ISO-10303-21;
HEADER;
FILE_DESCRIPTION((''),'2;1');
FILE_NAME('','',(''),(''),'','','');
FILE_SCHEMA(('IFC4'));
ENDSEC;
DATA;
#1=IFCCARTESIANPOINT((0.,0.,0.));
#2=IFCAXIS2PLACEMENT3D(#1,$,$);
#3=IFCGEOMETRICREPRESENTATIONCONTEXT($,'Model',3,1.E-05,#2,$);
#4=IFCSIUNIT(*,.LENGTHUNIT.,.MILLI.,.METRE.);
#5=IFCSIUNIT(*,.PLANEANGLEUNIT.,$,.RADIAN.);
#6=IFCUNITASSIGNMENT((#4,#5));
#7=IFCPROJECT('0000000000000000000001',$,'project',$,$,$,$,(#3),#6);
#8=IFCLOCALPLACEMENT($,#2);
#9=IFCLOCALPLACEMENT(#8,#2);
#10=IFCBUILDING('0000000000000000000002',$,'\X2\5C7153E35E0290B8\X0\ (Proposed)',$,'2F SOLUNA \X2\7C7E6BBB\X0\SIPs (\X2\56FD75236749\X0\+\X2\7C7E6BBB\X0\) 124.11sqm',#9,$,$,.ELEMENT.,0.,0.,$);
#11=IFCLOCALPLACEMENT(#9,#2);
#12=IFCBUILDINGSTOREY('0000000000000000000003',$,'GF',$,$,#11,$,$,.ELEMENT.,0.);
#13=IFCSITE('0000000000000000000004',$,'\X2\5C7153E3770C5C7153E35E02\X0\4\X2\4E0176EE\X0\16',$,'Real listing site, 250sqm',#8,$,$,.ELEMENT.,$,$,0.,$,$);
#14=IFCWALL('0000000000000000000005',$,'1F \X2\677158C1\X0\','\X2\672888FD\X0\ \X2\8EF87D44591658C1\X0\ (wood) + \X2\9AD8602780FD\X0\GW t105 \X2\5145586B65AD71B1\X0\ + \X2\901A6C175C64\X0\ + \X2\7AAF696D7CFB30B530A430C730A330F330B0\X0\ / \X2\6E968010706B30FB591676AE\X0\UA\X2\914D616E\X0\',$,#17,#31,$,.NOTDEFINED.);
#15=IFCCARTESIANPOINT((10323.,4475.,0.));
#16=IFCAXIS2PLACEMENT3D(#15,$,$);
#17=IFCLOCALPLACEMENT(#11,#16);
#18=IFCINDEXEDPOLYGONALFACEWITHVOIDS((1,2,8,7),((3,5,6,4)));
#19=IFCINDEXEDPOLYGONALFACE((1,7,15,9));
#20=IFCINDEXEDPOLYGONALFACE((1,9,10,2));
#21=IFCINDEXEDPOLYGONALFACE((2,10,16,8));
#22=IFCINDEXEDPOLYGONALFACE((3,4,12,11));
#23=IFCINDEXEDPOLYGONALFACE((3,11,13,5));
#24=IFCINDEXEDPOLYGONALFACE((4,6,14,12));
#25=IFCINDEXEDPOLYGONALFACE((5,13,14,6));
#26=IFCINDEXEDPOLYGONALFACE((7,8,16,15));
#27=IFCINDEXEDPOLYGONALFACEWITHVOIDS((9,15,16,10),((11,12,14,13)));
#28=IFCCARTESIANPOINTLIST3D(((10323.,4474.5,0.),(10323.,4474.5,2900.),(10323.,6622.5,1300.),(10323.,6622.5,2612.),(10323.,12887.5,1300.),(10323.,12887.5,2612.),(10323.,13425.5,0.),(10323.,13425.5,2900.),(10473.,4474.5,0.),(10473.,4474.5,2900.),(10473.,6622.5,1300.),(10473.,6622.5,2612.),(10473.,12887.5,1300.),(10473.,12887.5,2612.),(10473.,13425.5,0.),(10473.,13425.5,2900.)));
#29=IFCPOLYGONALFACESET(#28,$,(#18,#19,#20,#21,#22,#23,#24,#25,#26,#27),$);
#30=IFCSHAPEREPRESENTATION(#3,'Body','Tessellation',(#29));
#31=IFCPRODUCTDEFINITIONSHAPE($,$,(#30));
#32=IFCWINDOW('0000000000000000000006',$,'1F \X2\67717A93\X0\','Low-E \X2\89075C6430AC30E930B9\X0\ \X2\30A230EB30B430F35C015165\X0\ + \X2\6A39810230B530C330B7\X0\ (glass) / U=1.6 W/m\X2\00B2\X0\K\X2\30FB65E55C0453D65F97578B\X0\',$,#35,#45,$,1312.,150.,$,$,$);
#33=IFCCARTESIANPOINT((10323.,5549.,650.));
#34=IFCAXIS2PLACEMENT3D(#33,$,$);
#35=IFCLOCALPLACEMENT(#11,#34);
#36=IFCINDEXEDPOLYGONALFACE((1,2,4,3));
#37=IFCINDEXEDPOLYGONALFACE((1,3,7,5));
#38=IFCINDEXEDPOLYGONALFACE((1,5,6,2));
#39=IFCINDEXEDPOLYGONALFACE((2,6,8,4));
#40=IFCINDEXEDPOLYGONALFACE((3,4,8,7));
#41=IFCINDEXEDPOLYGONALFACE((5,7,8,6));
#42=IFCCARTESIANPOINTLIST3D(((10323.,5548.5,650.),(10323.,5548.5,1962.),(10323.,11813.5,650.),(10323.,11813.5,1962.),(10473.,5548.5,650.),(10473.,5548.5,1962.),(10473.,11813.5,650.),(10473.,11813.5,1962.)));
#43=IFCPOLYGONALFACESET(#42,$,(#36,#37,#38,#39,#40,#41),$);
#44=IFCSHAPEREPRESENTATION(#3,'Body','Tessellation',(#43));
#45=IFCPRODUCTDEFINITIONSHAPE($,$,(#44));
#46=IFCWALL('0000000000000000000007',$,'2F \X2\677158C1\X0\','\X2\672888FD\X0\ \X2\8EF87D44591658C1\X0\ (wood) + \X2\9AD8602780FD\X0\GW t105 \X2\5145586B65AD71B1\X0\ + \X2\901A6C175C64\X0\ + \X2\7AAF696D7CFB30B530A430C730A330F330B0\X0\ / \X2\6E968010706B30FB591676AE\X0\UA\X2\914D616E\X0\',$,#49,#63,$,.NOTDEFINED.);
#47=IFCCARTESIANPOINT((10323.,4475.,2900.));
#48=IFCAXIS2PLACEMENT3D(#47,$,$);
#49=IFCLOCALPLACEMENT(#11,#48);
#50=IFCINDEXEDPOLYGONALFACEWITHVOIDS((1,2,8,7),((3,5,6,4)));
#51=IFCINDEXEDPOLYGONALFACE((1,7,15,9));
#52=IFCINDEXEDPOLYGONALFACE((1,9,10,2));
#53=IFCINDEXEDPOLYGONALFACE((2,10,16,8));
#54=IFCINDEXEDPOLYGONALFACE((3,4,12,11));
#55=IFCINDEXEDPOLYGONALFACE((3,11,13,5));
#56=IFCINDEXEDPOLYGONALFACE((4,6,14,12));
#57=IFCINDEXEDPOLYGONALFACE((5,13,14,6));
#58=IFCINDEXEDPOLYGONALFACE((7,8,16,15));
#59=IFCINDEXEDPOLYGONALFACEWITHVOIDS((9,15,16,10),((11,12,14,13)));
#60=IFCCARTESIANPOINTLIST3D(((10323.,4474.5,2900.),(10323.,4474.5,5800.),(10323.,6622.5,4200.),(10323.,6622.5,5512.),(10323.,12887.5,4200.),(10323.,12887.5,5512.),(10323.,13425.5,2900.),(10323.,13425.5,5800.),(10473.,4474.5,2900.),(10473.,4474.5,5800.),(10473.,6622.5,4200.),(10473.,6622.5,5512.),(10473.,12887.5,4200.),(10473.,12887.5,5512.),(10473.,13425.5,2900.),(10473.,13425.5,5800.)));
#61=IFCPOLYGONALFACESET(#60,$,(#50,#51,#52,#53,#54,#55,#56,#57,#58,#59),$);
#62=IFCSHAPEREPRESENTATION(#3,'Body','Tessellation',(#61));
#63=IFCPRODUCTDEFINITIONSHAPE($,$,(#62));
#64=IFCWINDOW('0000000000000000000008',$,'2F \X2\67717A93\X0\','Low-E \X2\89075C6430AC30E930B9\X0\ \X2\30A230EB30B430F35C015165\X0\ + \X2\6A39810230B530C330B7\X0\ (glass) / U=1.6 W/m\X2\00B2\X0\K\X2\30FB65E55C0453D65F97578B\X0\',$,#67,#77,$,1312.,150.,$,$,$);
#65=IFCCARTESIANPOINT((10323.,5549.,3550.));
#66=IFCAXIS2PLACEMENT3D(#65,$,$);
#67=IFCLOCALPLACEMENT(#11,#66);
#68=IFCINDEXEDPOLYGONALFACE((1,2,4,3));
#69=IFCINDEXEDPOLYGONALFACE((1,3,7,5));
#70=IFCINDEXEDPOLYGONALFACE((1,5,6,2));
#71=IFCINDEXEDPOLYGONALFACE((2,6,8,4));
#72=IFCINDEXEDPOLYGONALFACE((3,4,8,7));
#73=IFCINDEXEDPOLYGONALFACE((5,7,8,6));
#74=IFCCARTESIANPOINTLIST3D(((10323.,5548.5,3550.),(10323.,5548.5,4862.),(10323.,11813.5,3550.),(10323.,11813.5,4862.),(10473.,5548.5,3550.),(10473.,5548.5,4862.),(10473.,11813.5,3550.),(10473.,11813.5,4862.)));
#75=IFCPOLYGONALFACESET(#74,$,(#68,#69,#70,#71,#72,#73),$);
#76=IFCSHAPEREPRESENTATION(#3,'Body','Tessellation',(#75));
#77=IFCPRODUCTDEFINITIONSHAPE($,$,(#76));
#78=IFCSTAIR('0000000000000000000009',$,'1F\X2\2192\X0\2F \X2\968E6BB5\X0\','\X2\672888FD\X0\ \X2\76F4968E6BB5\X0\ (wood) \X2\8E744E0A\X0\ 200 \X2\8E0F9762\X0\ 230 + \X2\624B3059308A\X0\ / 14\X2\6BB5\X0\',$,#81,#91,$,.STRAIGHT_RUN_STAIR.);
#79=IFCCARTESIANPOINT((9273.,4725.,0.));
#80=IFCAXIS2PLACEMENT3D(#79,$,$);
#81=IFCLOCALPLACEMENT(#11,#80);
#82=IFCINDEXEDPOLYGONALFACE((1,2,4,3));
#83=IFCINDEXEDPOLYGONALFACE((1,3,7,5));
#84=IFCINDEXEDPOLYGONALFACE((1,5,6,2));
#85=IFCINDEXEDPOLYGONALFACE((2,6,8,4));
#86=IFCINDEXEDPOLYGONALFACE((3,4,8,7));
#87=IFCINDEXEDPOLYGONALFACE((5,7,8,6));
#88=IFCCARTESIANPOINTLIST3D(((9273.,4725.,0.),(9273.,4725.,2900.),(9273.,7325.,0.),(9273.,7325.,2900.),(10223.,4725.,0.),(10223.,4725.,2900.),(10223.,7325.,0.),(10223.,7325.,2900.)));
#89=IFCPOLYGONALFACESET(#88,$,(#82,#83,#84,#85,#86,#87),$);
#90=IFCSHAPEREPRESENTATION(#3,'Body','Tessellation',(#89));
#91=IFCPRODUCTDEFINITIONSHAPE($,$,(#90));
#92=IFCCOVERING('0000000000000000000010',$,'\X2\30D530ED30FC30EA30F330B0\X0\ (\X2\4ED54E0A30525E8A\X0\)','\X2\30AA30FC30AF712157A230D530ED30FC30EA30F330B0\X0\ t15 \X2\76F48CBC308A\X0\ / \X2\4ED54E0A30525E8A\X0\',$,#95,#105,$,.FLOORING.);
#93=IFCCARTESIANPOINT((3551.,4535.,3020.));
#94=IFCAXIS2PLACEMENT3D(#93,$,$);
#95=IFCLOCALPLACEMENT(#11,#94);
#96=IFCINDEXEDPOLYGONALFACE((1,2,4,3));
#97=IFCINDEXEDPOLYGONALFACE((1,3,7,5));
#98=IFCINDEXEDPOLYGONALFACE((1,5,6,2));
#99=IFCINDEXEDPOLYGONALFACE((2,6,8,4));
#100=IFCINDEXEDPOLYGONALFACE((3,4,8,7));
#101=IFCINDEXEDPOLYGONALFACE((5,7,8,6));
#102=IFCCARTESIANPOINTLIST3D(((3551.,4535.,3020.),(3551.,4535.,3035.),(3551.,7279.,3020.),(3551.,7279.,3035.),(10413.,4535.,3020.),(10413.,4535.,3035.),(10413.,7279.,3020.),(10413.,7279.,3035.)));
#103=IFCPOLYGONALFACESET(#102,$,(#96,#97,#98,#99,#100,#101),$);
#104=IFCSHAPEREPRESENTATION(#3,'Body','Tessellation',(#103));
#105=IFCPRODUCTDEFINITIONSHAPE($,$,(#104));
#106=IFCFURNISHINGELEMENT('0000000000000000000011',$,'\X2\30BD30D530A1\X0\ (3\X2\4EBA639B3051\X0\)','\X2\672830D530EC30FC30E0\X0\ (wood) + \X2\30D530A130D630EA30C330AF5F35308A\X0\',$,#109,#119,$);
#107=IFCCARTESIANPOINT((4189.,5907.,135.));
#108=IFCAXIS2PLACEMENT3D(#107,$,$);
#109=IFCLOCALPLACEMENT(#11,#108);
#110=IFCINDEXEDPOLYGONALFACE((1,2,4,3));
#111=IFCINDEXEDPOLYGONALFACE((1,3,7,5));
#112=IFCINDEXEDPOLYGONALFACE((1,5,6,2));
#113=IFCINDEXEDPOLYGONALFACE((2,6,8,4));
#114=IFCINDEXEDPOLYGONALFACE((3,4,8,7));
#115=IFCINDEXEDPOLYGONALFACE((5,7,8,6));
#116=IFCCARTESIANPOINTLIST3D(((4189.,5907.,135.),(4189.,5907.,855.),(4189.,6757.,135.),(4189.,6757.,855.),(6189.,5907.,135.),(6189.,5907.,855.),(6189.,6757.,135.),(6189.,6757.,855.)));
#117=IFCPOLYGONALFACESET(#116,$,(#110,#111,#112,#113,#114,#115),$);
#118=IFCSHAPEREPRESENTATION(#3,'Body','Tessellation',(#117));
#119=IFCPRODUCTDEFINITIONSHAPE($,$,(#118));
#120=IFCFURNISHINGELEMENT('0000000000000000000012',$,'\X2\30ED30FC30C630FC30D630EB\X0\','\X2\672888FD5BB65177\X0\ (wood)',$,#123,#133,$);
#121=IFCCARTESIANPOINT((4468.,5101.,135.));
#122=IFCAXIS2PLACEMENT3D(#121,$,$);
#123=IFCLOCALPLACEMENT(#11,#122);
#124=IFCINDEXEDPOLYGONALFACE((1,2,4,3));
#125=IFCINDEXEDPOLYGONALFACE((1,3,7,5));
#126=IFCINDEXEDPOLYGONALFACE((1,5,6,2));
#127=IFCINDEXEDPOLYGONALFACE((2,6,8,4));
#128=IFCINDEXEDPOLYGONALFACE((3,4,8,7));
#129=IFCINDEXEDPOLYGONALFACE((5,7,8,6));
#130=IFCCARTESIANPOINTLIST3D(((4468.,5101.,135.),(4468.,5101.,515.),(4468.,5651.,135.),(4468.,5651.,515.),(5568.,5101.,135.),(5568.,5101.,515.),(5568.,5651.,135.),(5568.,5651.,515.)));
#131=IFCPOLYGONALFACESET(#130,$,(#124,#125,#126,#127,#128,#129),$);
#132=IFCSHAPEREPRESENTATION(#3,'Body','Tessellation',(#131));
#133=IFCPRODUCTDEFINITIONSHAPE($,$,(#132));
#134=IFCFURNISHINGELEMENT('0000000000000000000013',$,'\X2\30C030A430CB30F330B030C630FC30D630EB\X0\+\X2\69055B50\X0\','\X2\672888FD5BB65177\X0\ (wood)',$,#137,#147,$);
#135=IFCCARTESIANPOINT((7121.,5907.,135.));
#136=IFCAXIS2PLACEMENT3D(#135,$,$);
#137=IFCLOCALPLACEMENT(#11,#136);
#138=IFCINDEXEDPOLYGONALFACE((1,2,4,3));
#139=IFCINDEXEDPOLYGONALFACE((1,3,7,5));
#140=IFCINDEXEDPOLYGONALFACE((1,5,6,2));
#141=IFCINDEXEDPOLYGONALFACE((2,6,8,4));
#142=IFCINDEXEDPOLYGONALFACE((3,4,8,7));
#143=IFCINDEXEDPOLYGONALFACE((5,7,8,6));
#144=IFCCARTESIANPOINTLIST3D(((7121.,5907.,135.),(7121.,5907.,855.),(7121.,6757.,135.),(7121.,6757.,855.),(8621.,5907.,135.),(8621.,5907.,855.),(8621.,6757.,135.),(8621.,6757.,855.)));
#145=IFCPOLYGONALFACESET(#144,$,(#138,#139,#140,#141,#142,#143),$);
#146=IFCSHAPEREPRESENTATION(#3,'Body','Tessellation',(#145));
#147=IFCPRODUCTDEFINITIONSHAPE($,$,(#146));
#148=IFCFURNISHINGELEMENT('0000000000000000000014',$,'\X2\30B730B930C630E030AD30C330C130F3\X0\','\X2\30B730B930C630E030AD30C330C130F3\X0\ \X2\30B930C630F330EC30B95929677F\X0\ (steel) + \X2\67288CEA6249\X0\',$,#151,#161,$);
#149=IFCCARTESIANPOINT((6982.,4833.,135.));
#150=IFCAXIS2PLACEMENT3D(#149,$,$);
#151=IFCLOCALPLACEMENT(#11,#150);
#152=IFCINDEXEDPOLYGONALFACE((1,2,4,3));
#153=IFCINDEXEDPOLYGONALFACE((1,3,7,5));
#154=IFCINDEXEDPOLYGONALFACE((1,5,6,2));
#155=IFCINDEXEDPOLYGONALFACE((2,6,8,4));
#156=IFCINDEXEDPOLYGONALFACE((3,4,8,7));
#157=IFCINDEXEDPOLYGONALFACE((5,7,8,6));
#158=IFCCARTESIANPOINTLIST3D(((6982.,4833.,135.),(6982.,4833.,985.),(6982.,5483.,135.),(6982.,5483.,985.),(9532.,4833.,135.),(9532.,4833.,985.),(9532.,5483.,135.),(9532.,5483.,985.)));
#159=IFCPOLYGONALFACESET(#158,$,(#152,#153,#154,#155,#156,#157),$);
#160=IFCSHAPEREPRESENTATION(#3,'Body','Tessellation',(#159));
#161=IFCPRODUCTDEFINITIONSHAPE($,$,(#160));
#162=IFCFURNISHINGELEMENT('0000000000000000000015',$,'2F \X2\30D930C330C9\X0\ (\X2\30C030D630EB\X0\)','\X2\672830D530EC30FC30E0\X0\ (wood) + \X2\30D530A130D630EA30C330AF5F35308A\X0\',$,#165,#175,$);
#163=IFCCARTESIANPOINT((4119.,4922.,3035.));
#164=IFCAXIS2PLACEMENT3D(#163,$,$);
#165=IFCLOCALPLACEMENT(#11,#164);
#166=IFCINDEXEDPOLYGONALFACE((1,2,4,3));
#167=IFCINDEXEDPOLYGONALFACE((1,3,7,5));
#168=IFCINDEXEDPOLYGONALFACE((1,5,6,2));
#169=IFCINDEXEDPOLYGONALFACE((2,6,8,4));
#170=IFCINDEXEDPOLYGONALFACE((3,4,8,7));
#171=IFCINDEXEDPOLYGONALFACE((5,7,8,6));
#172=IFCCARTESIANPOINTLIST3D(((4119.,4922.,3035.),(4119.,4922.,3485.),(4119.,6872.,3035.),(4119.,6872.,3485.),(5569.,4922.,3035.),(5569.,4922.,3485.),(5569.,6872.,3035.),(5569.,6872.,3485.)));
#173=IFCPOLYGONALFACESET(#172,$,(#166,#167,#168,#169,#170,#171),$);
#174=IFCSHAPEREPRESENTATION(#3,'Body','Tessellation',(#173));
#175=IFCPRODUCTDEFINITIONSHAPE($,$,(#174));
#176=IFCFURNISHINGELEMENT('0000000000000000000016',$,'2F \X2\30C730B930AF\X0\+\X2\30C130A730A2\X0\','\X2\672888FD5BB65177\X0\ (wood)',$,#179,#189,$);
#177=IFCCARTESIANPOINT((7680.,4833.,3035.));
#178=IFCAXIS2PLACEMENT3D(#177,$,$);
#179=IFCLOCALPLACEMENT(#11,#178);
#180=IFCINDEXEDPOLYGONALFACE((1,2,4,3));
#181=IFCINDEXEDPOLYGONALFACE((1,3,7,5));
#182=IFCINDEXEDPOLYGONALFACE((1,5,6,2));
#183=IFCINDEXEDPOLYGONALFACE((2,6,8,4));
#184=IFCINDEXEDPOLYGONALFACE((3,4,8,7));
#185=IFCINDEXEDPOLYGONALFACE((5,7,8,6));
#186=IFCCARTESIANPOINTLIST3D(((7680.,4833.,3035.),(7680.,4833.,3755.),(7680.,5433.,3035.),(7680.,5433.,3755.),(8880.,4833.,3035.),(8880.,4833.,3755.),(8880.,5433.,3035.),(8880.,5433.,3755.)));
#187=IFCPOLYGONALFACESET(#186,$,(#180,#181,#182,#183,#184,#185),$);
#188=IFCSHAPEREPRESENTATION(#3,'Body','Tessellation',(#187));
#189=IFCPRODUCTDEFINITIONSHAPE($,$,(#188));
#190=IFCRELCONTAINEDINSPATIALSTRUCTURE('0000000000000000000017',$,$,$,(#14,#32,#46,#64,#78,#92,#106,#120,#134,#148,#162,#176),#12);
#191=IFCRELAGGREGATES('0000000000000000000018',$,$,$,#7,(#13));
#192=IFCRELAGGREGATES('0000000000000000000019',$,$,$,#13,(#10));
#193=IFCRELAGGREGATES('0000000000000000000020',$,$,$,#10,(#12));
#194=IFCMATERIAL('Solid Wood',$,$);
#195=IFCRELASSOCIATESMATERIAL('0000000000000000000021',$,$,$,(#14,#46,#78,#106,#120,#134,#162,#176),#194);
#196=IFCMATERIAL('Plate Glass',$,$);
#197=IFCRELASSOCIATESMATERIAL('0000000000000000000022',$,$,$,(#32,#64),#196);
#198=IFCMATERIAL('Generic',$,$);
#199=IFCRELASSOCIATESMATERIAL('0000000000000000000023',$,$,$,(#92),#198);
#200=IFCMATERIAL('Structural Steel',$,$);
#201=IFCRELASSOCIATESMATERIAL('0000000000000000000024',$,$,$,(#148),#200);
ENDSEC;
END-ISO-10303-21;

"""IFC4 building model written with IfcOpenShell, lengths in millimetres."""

from ifc_helpers import new_model, si_unit, frame, frame_2d, origin, place, context, project, spatial, rectangle, extrude, material, element, fill, save


model = new_model("IFC4")

# Units and contexts
model_context = context("Model", 3, precision=1e-05, world=origin())
ifc_project = project(units=[si_unit("LENGTHUNIT", "METRE", prefix="MILLI"), si_unit("PLANEANGLEUNIT", "RADIAN")], contexts=[model_context])

# Site, building, storey
site_placement = place(None, origin())
site = spatial("IfcSite", under=ifc_project, at=site_placement, Name="山口県山口市4丁目16", ObjectType="Real listing site, 250sqm", CompositionType="ELEMENT", RefElevation=0.0)
building_placement = place(site_placement, origin())
building = spatial("IfcBuilding", under=site, at=building_placement, Name="山口市邸 (Proposed)", ObjectType="2F SOLUNA 籾殻SIPs (国産杉+籾殻) 124.11sqm", CompositionType="ELEMENT", ElevationOfRefHeight=0.0, ElevationOfTerrain=0.0)
storey_placement = place(building_placement, origin())
storey = spatial("IfcBuildingStorey", under=building, at=storey_placement, Name="GF", CompositionType="ELEMENT", Elevation=0.0)

# Shared definitions
ifc_material_1 = material(Name="Solid Wood")

# Wall, opening, window
wall_1_placement = place(storey_placement, frame((10323.0, 4475.0, 0.0)))
wall_1 = element("IfcWall", 1, at=wall_1_placement, inside=storey, material=ifc_material_1, Name="1F 東壁", Description="木製 軸組外壁 (wood) + 高性能GW t105 充填断熱 + 通気層 + 窯業系サイディング / 準耐火・外皮UA配慮", PredefinedType="NOTDEFINED", context=model_context, shape_type="SweptSolid", body=[
    extrude(rectangle(XDim=150.0, YDim=8951.0, at=frame_2d((75.0, 4475.0))), frame((10323.0, 4475.0, 0.0)), (0.0, 0.0, 1.0), 2900.0),
])
opening_1_placement = place(storey_placement, frame((10323.0, 5549.0, 650.0)))
opening_1 = element("IfcOpeningElement", 2, at=opening_1_placement, cuts=wall_1, PredefinedType="NOTDEFINED", context=model_context, shape_type="SweptSolid", body=[
    extrude(rectangle(XDim=150.0, YDim=6265.0, at=frame_2d((75.0, 3132.0))), frame((10323.0, 5549.0, 650.0)), (0.0, 0.0, 1.0), 1312.0),
])
ifc_material_2 = material(Name="Plate Glass")
window_1_placement = place(storey_placement, frame((10323.0, 5549.0, 650.0)))
window_1 = element("IfcWindow", 3, at=window_1_placement, inside=storey, material=ifc_material_2, Name="1F 東窓", Description="Low-E 複層ガラス アルゴン封入 + 樹脂サッシ (glass) / U=1.6 W/m²K・日射取得型", OverallHeight=1312.0, OverallWidth=150.0, context=model_context, shape_type="SweptSolid", body=[
    extrude(rectangle(XDim=150.0, YDim=6265.0, at=frame_2d((75.0, 3132.0))), frame((10323.0, 5549.0, 650.0)), (0.0, 0.0, 1.0), 1312.0),
])
fill(opening_1, window_1)

# Wall, opening, window
wall_2_placement = place(storey_placement, frame((10323.0, 4475.0, 2900.0)))
wall_2 = element("IfcWall", 4, at=wall_2_placement, inside=storey, material=ifc_material_1, Name="2F 東壁", Description="木製 軸組外壁 (wood) + 高性能GW t105 充填断熱 + 通気層 + 窯業系サイディング / 準耐火・外皮UA配慮", PredefinedType="NOTDEFINED", context=model_context, shape_type="SweptSolid", body=[
    extrude(rectangle(XDim=150.0, YDim=8951.0, at=frame_2d((75.0, 4475.0))), frame((10323.0, 4475.0, 2900.0)), (0.0, 0.0, 1.0), 2900.0),
])
opening_2_placement = place(storey_placement, frame((10323.0, 5549.0, 3550.0)))
opening_2 = element("IfcOpeningElement", 5, at=opening_2_placement, cuts=wall_2, PredefinedType="NOTDEFINED", context=model_context, shape_type="SweptSolid", body=[
    extrude(rectangle(XDim=150.0, YDim=6265.0, at=frame_2d((75.0, 3132.0))), frame((10323.0, 5549.0, 3550.0)), (0.0, 0.0, 1.0), 1312.0),
])
window_2_placement = place(storey_placement, frame((10323.0, 5549.0, 3550.0)))
window_2 = element("IfcWindow", 6, at=window_2_placement, inside=storey, material=ifc_material_2, Name="2F 東窓", Description="Low-E 複層ガラス アルゴン封入 + 樹脂サッシ (glass) / U=1.6 W/m²K・日射取得型", OverallHeight=1312.0, OverallWidth=150.0, context=model_context, shape_type="SweptSolid", body=[
    extrude(rectangle(XDim=150.0, YDim=6265.0, at=frame_2d((75.0, 3132.0))), frame((10323.0, 5549.0, 3550.0)), (0.0, 0.0, 1.0), 1312.0),
])
fill(opening_2, window_2)

# Stair
stair_placement = place(storey_placement, frame((9273.0, 4725.0, 0.0)))
element("IfcStair", 7, at=stair_placement, inside=storey, material=ifc_material_1, Name="1F→2F 階段", Description="木製 直階段 (wood) 蹴上 200 踏面 230 + 手すり / 14段", PredefinedType="STRAIGHT_RUN_STAIR", context=model_context, shape_type="SweptSolid", body=[
    extrude(rectangle(XDim=950.0, YDim=2600.0, at=frame_2d((475.0, 1300.0))), frame((9273.0, 4725.0, 0.0)), (0.0, 0.0, 1.0), 2900.0),
])

# Covering
ifc_material_3 = material(Name="Generic")
covering_placement = place(storey_placement, frame((3551.0, 4535.0, 3020.0)))
element("IfcCovering", 8, at=covering_placement, inside=storey, material=ifc_material_3, Name="フローリング (仕上げ床)", Description="オーク無垢フローリング t15 直貼り / 仕上げ床", PredefinedType="FLOORING", context=model_context, shape_type="SweptSolid", body=[
    extrude(rectangle(XDim=6862.0, YDim=2744.0, at=frame_2d((3431.0, 1372.0))), frame((3551.0, 4535.0, 3020.0)), (0.0, 0.0, 1.0), 15.0),
])

# Furnishing elements
furnishing_1_placement = place(storey_placement, frame((4189.0, 5907.0, 135.0)))
element("IfcFurnishingElement", 9, at=furnishing_1_placement, inside=storey, material=ifc_material_1, Name="ソファ (3人掛け)", Description="木フレーム (wood) + ファブリック張り", context=model_context, shape_type="SweptSolid", body=[
    extrude(rectangle(XDim=2000.0, YDim=850.0, at=frame_2d((1000.0, 425.0))), frame((4189.0, 5907.0, 135.0)), (0.0, 0.0, 1.0), 720.0),
])
furnishing_2_placement = place(storey_placement, frame((4468.0, 5101.0, 135.0)))
element("IfcFurnishingElement", 10, at=furnishing_2_placement, inside=storey, material=ifc_material_1, Name="ローテーブル", Description="木製家具 (wood)", context=model_context, shape_type="SweptSolid", body=[
    extrude(rectangle(XDim=1100.0, YDim=550.0, at=frame_2d((550.0, 275.0))), frame((4468.0, 5101.0, 135.0)), (0.0, 0.0, 1.0), 380.0),
])
furnishing_3_placement = place(storey_placement, frame((7121.0, 5907.0, 135.0)))
element("IfcFurnishingElement", 11, at=furnishing_3_placement, inside=storey, material=ifc_material_1, Name="ダイニングテーブル+椅子", Description="木製家具 (wood)", context=model_context, shape_type="SweptSolid", body=[
    extrude(rectangle(XDim=1500.0, YDim=850.0, at=frame_2d((750.0, 425.0))), frame((7121.0, 5907.0, 135.0)), (0.0, 0.0, 1.0), 720.0),
])
ifc_material_4 = material(Name="Structural Steel")
furnishing_4_placement = place(storey_placement, frame((6982.0, 4833.0, 135.0)))
element("IfcFurnishingElement", 12, at=furnishing_4_placement, inside=storey, material=ifc_material_4, Name="システムキッチン", Description="システムキッチン ステンレス天板 (steel) + 木質扉", context=model_context, shape_type="SweptSolid", body=[
    extrude(rectangle(XDim=2550.0, YDim=650.0, at=frame_2d((1275.0, 325.0))), frame((6982.0, 4833.0, 135.0)), (0.0, 0.0, 1.0), 850.0),
])
furnishing_5_placement = place(storey_placement, frame((4119.0, 4922.0, 3035.0)))
element("IfcFurnishingElement", 13, at=furnishing_5_placement, inside=storey, material=ifc_material_1, Name="2F ベッド (ダブル)", Description="木フレーム (wood) + ファブリック張り", context=model_context, shape_type="SweptSolid", body=[
    extrude(rectangle(XDim=1450.0, YDim=1950.0, at=frame_2d((725.0, 975.0))), frame((4119.0, 4922.0, 3035.0)), (0.0, 0.0, 1.0), 450.0),
])
furnishing_6_placement = place(storey_placement, frame((7680.0, 4833.0, 3035.0)))
element("IfcFurnishingElement", 14, at=furnishing_6_placement, inside=storey, material=ifc_material_1, Name="2F デスク+チェア", Description="木製家具 (wood)", context=model_context, shape_type="SweptSolid", body=[
    extrude(rectangle(XDim=1200.0, YDim=600.0, at=frame_2d((600.0, 300.0))), frame((7680.0, 4833.0, 3035.0)), (0.0, 0.0, 1.0), 720.0),
])

save(model, "model.ifc")
